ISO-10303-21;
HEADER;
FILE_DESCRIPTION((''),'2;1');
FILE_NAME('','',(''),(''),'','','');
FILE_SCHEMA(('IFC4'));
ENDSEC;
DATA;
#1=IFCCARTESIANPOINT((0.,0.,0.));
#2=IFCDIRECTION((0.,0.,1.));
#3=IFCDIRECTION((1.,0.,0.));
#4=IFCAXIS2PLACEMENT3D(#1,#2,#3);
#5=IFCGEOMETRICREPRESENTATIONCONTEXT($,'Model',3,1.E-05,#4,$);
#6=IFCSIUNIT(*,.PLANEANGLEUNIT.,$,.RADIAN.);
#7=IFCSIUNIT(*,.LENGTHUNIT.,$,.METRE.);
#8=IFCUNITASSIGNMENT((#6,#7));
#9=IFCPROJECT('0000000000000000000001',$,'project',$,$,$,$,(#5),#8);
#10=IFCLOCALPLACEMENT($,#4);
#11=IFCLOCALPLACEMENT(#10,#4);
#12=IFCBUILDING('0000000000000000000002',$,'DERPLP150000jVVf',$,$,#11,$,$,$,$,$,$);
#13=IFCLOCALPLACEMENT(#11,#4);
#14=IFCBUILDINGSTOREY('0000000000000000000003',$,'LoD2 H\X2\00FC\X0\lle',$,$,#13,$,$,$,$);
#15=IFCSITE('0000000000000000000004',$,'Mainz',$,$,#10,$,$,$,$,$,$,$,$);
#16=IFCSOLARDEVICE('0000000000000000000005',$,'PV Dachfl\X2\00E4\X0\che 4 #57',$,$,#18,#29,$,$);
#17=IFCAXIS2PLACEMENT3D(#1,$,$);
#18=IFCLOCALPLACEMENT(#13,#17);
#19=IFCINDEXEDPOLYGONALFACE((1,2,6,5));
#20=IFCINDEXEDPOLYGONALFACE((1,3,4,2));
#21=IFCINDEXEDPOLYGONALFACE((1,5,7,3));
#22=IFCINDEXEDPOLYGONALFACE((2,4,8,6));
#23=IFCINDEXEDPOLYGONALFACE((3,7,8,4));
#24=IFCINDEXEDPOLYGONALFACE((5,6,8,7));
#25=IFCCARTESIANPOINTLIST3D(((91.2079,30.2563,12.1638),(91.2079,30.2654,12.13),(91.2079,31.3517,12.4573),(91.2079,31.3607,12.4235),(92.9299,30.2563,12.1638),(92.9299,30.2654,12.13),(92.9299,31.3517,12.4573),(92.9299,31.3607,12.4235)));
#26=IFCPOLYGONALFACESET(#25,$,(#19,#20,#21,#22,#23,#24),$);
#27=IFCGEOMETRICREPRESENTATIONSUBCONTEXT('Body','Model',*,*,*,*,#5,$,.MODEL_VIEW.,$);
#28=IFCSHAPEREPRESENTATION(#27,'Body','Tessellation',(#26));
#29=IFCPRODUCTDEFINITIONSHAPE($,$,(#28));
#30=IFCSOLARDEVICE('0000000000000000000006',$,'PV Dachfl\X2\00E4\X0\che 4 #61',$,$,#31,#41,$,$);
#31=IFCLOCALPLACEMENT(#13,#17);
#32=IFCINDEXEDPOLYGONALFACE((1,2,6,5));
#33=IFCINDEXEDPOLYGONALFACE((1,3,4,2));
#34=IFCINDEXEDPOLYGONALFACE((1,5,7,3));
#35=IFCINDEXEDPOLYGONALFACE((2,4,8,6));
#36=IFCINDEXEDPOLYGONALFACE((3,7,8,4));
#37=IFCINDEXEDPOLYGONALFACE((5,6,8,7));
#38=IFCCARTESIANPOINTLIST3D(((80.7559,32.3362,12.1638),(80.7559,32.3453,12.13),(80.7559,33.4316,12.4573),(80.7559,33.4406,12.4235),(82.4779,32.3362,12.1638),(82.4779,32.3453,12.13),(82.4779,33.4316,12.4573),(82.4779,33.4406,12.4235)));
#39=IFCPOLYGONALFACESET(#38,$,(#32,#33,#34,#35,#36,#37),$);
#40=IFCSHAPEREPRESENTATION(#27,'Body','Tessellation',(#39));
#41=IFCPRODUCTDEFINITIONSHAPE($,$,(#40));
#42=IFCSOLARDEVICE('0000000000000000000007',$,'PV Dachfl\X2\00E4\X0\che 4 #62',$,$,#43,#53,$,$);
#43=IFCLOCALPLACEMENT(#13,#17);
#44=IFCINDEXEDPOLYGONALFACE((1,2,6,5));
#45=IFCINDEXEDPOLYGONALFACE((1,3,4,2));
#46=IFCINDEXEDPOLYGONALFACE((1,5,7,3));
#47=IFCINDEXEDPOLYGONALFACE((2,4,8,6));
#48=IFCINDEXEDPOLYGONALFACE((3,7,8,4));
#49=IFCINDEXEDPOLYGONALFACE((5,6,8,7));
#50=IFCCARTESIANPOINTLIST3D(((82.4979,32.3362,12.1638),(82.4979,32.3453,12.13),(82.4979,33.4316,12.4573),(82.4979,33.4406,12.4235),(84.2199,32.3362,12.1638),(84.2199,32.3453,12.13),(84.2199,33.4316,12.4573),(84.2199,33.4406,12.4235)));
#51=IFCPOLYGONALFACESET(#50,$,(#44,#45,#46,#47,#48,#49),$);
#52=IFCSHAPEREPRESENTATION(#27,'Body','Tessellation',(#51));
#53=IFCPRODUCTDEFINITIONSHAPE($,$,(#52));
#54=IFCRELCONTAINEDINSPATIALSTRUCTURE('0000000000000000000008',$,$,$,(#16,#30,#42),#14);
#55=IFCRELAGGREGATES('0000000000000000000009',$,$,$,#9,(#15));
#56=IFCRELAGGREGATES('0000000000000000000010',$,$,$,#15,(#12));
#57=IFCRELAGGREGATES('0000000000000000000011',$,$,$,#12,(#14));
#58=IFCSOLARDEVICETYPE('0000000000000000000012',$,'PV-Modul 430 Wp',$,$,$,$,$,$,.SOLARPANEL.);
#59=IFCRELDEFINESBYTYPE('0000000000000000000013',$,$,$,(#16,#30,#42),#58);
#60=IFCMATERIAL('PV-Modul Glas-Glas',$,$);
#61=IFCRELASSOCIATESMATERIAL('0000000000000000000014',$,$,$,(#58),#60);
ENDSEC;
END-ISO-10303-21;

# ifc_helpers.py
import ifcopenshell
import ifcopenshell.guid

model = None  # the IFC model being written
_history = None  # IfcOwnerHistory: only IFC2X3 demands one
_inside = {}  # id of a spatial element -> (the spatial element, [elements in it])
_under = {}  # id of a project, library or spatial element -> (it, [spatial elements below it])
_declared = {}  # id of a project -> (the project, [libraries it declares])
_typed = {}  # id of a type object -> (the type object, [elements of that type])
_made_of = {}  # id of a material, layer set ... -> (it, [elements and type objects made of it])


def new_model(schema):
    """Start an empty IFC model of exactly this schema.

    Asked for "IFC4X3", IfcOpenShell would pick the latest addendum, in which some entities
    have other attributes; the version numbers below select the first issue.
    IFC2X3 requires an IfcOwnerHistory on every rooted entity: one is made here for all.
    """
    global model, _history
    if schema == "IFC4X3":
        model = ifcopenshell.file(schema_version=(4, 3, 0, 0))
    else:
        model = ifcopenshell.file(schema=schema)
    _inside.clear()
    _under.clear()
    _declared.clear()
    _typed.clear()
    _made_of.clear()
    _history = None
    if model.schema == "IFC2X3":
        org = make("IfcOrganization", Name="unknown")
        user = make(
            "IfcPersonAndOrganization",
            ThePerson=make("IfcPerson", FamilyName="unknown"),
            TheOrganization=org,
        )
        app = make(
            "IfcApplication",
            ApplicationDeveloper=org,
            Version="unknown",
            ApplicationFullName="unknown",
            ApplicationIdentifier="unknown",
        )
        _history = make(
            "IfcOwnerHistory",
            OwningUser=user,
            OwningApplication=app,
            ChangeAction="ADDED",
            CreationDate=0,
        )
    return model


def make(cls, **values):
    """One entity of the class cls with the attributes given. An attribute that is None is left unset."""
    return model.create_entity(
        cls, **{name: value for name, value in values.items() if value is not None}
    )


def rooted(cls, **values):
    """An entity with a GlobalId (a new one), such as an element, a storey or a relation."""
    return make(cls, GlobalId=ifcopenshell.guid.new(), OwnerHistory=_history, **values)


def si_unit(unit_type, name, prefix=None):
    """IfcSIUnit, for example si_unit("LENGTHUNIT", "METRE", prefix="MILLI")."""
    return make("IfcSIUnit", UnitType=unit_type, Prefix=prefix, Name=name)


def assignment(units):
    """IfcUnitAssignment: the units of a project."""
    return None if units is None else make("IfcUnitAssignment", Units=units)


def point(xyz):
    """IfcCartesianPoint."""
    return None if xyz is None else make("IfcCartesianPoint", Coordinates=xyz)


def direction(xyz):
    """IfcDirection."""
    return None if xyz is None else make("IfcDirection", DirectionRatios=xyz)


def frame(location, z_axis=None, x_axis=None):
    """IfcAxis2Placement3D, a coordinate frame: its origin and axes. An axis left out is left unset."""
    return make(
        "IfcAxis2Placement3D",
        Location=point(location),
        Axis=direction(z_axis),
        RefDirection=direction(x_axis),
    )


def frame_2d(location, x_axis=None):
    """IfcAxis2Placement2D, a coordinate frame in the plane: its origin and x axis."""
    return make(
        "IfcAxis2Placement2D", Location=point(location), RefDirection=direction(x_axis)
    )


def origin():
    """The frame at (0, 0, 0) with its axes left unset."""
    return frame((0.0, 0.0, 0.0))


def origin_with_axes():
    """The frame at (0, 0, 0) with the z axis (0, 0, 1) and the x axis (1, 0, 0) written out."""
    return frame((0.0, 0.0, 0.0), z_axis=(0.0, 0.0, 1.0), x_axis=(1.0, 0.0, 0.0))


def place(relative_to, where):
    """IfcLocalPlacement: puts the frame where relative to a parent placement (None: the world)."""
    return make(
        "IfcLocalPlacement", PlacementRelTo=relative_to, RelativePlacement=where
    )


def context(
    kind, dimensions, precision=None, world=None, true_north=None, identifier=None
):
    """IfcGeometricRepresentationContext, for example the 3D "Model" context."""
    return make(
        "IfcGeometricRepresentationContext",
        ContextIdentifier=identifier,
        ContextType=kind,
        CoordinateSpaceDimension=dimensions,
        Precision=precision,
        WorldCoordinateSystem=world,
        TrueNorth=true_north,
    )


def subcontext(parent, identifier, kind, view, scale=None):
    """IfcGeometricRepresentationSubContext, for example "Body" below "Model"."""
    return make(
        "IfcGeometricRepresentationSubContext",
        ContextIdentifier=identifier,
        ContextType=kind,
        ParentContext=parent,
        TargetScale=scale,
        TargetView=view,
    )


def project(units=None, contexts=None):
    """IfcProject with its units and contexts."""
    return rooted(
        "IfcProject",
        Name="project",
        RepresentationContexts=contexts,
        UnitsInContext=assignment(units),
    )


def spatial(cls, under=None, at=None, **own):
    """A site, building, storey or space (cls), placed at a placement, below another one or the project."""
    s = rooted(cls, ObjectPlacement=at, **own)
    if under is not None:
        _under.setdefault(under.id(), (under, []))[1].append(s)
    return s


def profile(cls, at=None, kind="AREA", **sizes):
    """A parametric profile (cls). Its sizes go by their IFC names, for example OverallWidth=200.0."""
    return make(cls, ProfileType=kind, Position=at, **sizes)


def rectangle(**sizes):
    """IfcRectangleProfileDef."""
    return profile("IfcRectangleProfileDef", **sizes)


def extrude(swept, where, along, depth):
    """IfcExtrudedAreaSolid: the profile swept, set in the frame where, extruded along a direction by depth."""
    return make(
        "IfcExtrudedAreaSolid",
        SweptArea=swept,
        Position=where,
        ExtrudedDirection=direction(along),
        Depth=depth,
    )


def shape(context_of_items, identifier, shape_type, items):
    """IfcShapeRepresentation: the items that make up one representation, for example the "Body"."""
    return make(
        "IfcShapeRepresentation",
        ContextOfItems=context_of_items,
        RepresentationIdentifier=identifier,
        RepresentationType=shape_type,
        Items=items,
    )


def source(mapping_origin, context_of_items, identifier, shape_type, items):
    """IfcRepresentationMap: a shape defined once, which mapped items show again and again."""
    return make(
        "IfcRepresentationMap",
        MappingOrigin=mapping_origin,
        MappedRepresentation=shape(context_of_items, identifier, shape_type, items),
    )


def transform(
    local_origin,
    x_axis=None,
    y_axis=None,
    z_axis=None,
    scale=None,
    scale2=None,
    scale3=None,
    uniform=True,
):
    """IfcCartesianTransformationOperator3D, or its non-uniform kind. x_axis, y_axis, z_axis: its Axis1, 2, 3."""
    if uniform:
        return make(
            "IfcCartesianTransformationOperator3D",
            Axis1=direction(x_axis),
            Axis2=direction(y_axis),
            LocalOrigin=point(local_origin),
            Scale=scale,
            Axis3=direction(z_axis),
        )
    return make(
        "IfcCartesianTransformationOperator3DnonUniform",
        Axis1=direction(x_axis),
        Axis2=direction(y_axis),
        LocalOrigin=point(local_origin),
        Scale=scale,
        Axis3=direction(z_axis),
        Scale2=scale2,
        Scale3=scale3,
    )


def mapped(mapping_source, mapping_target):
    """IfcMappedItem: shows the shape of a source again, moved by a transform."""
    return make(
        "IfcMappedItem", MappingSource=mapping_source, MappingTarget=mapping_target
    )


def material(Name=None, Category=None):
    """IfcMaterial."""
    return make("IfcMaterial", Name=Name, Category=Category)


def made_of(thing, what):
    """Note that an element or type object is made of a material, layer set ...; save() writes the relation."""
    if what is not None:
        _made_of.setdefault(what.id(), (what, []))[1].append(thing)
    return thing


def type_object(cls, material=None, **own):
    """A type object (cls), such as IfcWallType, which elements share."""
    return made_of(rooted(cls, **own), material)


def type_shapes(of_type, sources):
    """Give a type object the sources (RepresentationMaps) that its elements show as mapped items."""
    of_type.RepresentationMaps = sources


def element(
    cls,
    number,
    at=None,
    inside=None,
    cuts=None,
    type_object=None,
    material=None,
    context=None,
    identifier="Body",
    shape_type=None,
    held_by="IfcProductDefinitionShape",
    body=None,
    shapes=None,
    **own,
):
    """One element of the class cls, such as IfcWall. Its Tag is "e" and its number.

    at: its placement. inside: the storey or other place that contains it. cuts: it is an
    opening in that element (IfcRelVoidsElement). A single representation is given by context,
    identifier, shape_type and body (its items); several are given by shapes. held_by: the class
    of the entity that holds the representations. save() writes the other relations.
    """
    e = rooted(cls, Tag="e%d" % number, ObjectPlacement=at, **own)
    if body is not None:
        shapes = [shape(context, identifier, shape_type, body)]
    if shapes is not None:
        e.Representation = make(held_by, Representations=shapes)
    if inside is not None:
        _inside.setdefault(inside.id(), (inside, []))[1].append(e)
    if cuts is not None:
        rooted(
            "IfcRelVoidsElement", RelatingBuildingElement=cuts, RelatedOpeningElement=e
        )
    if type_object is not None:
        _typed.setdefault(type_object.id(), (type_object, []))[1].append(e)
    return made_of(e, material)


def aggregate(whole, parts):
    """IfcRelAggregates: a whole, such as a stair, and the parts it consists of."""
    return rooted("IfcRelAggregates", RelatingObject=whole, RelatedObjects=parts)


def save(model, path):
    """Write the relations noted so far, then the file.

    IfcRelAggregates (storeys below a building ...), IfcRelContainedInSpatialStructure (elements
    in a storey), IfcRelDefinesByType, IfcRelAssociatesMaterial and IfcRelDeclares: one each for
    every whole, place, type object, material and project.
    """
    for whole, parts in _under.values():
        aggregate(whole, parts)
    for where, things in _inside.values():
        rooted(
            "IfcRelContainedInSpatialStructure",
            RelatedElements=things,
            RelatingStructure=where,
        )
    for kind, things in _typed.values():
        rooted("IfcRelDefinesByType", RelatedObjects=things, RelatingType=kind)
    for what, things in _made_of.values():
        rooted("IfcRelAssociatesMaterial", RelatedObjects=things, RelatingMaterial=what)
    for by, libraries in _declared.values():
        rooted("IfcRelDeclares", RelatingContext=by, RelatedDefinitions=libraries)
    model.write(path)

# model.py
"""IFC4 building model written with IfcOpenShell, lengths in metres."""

from ifc_helpers import new_model, si_unit, frame, frame_2d, origin, origin_with_axes, place, context, subcontext, project, spatial, rectangle, extrude, source, transform, mapped, material, type_object, type_shapes, element, save


model = new_model("IFC4")

# Units and contexts
model_context = context("Model", 3, precision=1e-05, world=origin_with_axes())
body_context = subcontext(model_context, "Body", "Model", "MODEL_VIEW")
ifc_project = project(units=[si_unit("PLANEANGLEUNIT", "RADIAN"), si_unit("LENGTHUNIT", "METRE")], contexts=[model_context])

# Site, building, storey
site_placement = place(None, origin_with_axes())
site = spatial("IfcSite", under=ifc_project, at=site_placement, Name="Mainz")
building_placement = place(site_placement, origin_with_axes())
building = spatial("IfcBuilding", under=site, at=building_placement, Name="DERPLP150000jVVf")
storey_placement = place(building_placement, origin_with_axes())
storey = spatial("IfcBuildingStorey", under=building, at=storey_placement, Name="LoD2 Hülle")

# Solar devices
ifc_material = material(Name="PV-Modul Glas-Glas")
solar_device_type = type_object("IfcSolarDeviceType", Name="PV-Modul 430 Wp", PredefinedType="SOLARPANEL", material=ifc_material)
shared_shape = source(origin_with_axes(), body_context, "Body", "SweptSolid", [
    extrude(rectangle(XDim=1.722, YDim=1.134, at=frame_2d((0.861, 0.567))), origin(), (0.0, 0.0, 1.0), 0.035),
])
type_shapes(solar_device_type, [shared_shape])
for number, where, z_axis, x_axis, name in (
    (1, (91.2079, 30.2654, 12.13), (0.0, -0.258819, 0.965926), (1.0, 0.0, 0.0), "PV Dachfläche 4 #57"),
    (2, (80.7559, 32.3453, 12.13), (0.0, -0.258819, 0.965926), (1.0, 0.0, 0.0), "PV Dachfläche 4 #61"),
    (3, (82.4979, 32.3453, 12.13), (0.0, -0.258819, 0.965926), (1.0, 0.0, 0.0), "PV Dachfläche 4 #62"),
):
    element("IfcSolarDevice", number, at=place(storey_placement, frame(where, z_axis=z_axis, x_axis=x_axis)), inside=storey, type_object=solar_device_type, Name=name, context=body_context, shape_type="MappedRepresentation", body=[
        mapped(shared_shape, transform((0.0, 0.0, 0.0), x_axis=(1.0, 0.0, 0.0), y_axis=(0.0, 1.0, 0.0), z_axis=(0.0, 0.0, 1.0), scale=1.0)),
    ])

save(model, "model.ifc")
